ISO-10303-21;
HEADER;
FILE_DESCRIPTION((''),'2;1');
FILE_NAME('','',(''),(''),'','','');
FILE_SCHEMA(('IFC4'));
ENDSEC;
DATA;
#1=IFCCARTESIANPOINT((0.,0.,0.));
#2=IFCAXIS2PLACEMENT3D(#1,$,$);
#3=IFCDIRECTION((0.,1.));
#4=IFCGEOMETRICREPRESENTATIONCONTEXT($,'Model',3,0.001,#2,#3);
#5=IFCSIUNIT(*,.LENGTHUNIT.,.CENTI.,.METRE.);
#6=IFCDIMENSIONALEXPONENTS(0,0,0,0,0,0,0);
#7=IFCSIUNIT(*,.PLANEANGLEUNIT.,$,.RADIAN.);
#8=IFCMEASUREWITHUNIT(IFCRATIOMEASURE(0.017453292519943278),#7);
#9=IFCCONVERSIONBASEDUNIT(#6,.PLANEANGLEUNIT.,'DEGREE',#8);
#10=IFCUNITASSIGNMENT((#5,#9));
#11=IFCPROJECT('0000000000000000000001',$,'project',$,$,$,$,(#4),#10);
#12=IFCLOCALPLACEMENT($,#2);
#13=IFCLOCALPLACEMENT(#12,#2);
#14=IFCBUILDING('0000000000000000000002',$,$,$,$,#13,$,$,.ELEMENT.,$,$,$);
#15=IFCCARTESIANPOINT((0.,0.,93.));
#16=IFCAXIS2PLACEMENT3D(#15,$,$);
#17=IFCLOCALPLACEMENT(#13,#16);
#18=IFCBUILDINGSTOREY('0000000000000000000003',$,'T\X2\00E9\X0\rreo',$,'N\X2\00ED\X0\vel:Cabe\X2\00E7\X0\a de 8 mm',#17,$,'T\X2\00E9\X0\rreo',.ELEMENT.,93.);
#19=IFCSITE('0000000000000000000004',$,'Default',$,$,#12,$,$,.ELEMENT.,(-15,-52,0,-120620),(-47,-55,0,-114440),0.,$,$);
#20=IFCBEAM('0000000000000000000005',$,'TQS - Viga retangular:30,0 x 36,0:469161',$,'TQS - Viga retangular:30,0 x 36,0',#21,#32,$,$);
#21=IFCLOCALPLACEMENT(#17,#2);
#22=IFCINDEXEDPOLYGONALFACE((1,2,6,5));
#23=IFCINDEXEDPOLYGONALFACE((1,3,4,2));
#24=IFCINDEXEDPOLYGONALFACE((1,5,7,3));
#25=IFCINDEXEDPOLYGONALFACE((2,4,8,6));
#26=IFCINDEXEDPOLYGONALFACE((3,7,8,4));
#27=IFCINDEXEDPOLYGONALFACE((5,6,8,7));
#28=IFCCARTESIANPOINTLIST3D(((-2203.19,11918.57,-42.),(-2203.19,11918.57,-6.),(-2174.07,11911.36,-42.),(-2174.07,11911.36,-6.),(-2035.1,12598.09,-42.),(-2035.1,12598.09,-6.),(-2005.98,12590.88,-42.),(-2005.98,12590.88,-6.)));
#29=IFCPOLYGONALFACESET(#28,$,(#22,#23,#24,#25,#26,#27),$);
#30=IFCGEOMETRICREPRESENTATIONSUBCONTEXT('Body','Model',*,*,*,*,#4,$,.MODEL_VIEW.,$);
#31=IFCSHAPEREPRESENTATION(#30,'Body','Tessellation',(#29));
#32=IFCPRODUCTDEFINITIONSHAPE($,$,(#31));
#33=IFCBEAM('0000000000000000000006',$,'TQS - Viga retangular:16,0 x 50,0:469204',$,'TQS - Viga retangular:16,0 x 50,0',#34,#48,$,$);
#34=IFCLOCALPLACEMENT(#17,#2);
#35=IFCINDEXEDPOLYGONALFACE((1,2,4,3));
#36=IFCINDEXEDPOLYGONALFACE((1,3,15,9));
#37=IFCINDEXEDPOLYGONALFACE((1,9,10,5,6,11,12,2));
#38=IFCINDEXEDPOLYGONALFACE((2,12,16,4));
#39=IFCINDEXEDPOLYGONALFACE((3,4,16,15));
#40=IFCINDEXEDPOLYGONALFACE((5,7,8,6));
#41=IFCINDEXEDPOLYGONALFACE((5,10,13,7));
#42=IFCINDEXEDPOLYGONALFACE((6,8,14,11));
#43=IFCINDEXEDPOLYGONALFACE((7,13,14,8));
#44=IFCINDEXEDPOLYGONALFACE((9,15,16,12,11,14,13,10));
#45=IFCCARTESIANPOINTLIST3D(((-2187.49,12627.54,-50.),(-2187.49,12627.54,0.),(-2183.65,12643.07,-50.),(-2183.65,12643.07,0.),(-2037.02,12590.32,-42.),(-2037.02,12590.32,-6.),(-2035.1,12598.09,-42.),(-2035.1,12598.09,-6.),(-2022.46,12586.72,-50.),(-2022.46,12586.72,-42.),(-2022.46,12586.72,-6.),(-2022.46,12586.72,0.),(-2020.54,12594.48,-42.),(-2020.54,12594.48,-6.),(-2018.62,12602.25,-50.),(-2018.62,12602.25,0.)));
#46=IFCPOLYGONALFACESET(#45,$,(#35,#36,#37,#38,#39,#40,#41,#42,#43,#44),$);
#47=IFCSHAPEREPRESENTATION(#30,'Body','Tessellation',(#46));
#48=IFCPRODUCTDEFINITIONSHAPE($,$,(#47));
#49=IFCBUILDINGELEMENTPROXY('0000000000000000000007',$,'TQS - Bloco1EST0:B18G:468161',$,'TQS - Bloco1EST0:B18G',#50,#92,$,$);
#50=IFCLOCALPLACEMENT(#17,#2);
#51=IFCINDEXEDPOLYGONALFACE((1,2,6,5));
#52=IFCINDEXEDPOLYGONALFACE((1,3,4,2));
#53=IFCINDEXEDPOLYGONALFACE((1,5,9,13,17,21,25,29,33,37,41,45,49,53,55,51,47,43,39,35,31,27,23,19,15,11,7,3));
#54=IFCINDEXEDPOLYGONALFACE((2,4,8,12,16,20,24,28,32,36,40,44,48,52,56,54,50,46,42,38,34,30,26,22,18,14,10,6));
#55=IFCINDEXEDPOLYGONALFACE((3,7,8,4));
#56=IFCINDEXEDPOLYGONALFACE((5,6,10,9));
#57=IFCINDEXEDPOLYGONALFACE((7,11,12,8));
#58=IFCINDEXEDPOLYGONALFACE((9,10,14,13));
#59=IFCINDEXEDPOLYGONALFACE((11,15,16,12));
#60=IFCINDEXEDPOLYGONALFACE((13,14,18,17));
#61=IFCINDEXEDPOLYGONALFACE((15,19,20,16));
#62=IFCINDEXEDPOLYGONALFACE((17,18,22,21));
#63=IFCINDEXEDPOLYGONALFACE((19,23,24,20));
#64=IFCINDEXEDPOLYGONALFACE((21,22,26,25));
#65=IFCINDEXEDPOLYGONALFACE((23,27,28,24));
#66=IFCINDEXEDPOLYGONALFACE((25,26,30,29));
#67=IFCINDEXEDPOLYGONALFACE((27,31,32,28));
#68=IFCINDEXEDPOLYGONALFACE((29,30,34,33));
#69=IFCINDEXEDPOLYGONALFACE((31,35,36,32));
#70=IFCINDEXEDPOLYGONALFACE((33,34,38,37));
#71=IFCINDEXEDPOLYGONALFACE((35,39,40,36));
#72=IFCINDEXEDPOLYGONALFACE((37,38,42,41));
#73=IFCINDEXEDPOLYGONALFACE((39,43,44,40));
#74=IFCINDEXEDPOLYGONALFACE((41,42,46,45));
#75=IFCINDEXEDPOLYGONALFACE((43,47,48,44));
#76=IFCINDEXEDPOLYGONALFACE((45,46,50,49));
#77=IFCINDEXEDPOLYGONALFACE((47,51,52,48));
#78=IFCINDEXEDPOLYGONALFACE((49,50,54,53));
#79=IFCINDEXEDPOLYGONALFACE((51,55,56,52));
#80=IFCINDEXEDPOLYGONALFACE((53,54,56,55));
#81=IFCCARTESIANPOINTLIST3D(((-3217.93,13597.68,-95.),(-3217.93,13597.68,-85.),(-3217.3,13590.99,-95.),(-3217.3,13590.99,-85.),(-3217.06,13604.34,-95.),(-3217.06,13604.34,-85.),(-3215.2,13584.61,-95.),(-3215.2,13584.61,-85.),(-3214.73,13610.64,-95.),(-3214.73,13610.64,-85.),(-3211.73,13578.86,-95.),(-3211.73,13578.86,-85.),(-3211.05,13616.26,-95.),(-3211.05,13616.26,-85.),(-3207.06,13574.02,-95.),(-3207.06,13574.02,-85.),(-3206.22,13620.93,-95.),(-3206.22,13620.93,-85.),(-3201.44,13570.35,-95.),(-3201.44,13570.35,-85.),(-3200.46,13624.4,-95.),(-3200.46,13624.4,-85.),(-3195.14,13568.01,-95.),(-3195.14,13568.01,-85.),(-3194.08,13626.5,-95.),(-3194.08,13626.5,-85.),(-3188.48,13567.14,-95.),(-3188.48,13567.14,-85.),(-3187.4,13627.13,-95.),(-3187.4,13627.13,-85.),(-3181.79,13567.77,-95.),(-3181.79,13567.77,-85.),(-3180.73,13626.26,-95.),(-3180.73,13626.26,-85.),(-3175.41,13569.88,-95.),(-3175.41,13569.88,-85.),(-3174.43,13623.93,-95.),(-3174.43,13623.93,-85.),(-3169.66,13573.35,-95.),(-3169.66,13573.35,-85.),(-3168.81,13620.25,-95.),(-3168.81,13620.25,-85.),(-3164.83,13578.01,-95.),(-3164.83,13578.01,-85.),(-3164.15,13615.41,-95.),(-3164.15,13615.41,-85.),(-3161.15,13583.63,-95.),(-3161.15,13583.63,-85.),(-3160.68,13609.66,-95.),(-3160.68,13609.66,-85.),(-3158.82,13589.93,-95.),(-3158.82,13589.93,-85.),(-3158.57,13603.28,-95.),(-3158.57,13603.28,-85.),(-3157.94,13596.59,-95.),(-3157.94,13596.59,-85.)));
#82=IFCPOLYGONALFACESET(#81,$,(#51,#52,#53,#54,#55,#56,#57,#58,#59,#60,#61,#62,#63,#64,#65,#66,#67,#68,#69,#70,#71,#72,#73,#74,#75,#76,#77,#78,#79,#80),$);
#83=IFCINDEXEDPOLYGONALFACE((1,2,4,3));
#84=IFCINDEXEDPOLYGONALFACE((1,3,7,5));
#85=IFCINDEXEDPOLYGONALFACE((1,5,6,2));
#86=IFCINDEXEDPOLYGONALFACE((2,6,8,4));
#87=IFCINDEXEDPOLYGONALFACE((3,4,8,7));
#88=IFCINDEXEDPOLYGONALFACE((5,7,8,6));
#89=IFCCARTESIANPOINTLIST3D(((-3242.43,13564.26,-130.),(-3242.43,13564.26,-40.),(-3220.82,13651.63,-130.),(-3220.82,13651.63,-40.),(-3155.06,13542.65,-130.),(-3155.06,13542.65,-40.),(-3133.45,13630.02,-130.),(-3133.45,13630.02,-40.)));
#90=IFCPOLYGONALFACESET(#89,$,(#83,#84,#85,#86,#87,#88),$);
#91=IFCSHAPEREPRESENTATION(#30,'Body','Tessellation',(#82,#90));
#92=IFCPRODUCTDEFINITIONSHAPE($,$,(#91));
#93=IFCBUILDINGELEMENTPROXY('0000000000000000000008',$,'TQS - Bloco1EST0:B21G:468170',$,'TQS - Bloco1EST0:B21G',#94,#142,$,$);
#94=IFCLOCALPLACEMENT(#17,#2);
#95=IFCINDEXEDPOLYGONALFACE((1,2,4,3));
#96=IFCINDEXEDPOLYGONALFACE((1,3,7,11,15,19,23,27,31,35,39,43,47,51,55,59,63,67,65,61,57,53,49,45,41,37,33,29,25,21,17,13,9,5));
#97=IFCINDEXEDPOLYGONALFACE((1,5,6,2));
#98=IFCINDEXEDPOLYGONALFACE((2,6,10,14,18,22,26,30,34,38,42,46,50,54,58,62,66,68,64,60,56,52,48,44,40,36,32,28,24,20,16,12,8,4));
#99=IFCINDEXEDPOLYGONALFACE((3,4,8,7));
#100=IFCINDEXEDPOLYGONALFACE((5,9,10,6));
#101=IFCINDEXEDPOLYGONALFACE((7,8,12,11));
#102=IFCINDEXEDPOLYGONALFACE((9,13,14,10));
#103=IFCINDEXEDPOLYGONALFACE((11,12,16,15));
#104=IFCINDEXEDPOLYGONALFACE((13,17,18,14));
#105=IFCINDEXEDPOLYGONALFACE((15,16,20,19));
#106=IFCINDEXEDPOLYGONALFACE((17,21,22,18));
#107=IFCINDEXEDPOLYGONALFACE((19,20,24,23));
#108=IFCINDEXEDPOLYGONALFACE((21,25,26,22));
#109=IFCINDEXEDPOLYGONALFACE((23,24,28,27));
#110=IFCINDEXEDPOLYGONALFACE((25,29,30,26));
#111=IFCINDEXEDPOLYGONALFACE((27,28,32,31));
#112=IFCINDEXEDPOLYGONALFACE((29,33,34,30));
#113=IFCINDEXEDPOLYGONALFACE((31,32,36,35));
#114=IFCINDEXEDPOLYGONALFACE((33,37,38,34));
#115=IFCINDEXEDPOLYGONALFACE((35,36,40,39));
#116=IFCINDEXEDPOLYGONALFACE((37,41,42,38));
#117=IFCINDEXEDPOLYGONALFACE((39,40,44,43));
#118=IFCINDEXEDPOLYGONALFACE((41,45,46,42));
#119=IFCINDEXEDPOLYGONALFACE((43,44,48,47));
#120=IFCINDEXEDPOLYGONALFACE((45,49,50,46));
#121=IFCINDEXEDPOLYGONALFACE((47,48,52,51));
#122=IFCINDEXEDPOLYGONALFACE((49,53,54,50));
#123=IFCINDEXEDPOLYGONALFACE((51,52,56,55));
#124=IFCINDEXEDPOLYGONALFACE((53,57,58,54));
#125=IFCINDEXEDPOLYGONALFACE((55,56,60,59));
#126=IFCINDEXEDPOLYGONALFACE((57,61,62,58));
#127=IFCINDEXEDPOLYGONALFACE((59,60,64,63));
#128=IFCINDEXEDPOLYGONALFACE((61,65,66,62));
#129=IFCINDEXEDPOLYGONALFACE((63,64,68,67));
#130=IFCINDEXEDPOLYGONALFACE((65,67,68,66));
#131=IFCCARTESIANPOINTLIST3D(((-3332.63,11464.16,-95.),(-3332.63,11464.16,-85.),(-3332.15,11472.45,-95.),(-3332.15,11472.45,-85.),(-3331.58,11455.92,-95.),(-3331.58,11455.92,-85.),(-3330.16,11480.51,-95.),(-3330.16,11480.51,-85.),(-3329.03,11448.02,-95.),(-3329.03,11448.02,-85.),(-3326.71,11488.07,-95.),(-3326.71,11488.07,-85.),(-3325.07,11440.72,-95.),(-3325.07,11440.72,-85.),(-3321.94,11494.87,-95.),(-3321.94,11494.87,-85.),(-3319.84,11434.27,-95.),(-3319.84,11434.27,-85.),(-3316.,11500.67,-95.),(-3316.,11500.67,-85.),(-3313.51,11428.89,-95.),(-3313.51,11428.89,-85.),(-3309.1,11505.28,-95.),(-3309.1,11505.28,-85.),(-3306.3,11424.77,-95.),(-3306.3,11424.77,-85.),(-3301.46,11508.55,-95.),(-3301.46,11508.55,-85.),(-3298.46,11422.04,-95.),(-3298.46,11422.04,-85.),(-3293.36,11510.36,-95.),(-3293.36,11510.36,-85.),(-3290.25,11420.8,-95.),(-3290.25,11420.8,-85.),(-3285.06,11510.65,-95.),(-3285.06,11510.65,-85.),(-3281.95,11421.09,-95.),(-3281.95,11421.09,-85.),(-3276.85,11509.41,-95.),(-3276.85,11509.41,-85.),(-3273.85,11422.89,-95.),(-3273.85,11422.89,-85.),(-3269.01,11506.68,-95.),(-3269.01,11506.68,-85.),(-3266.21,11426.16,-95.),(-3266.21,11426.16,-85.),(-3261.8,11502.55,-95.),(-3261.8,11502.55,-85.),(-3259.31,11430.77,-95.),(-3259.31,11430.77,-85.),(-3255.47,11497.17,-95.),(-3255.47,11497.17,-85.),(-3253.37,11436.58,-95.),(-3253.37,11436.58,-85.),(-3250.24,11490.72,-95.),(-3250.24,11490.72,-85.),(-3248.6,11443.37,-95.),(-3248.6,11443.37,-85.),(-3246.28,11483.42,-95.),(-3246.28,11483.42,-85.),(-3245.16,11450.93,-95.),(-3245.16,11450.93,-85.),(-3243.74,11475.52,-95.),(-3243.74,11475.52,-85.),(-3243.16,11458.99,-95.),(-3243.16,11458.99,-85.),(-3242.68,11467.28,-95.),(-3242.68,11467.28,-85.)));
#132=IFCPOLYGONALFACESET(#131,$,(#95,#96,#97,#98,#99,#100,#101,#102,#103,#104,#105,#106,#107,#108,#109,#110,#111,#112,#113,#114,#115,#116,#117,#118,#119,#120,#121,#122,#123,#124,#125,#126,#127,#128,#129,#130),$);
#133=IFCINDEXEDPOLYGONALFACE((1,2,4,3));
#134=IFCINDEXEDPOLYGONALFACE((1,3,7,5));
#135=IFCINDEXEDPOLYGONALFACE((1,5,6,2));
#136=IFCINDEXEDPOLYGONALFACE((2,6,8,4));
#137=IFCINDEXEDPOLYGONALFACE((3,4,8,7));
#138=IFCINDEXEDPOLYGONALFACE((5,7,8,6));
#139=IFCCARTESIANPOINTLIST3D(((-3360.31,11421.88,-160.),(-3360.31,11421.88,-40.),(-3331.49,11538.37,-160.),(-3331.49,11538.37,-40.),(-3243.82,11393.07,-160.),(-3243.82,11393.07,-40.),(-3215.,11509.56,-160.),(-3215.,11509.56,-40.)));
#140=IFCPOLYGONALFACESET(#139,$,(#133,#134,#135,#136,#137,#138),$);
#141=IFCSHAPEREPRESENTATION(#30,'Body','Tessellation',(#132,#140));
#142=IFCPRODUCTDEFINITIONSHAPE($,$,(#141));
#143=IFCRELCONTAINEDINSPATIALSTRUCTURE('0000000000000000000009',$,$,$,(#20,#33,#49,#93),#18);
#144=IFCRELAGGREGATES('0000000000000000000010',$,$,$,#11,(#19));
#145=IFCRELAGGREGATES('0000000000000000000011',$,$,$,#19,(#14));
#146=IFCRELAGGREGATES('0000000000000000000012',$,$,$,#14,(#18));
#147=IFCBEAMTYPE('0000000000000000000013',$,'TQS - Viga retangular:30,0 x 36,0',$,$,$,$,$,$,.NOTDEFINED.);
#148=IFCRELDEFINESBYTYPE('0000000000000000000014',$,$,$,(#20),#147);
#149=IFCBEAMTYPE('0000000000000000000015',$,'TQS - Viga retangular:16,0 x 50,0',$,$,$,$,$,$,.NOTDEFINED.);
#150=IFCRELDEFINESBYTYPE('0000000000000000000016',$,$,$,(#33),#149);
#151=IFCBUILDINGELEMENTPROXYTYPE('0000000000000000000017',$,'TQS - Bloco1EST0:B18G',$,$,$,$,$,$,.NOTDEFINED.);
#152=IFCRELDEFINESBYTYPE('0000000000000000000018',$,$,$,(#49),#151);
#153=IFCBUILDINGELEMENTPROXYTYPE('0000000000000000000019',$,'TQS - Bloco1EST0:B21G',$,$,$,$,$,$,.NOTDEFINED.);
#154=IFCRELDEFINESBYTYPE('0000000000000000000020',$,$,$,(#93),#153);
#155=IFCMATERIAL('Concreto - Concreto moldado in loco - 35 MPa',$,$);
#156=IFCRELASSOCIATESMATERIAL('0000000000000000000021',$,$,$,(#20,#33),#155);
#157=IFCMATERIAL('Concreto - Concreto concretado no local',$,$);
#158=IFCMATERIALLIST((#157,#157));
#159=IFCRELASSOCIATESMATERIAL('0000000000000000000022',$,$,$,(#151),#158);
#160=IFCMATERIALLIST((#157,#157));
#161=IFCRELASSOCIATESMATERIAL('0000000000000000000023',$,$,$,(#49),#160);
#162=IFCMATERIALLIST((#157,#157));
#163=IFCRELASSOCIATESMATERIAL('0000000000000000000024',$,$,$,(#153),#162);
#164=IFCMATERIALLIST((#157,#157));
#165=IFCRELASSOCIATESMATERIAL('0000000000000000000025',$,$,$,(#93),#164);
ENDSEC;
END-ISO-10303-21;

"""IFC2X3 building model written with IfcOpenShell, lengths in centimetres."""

from ifc_helpers import new_model, entity, si_unit, converted_unit, direction, frame, frame_2d, origin, origin_2d_with_axis, place, context, subcontext, project, spatial, polyline, rectangle, circle, extrude, boolean, clip, bounded_halfspace, source, transform, mapped, material, material_list, type_object, type_shapes, element, save


model = new_model("IFC2X3")

# Units and contexts
model_context = context("Model", 3, precision=0.001, world=origin(), true_north=direction((0.0, 1.0)))
body_context = subcontext(model_context, "Body", "Model", "MODEL_VIEW")
ifc_project = project(units=[si_unit("LENGTHUNIT", "METRE", prefix="CENTI"), converted_unit("PLANEANGLEUNIT", "DEGREE", entity("IfcRatioMeasure", 0.017453292519943278), si_unit("PLANEANGLEUNIT", "RADIAN"), dimensions=[0, 0, 0, 0, 0, 0, 0])], contexts=[model_context])

# Site, building, storey
site_placement = place(None, origin())
site = spatial("IfcSite", under=ifc_project, at=site_placement, Name="Default", CompositionType="ELEMENT", RefLatitude=(-15, -52, 0, -120620), RefLongitude=(-47, -55, 0, -114440), RefElevation=0.0)
building_placement = place(site_placement, origin())
building = spatial("IfcBuilding", under=site, at=building_placement, CompositionType="ELEMENT")
storey_placement = place(building_placement, frame((0.0, 0.0, 93.0)))
storey = spatial("IfcBuildingStorey", under=building, at=storey_placement, Name="Térreo", ObjectType="Nível:Cabeça de 8 mm", LongName="Térreo", CompositionType="ELEMENT", Elevation=93.0)

# Beams
ifc_material_1 = material(Name="Concreto - Concreto moldado in loco - 35 MPa")
beam_type_1 = type_object("IfcBeamType", Name="TQS - Viga retangular:30,0 x 36,0", PredefinedType="NOTDEFINED")
beam_1_placement = place(storey_placement, frame((-2188.63, 11914.96, -6.0), z_axis=(0.0, 0.0, 1.0), x_axis=(0.240122, 0.970743, 0.0)))
element("IfcBeam", 1, at=beam_1_placement, inside=storey, type_object=beam_type_1, material=ifc_material_1, Name="TQS - Viga retangular:30,0 x 36,0:469161", ObjectType="TQS - Viga retangular:30,0 x 36,0", context=body_context, shape_type="SweptSolid", body=[
    extrude(rectangle(XDim=36.0, YDim=30.0, at=frame_2d((0.0, 0.0), x_axis=(1.0, 0.0))), frame((0.0, 0.0, -18.0), z_axis=(1.0, 0.0, 0.0), x_axis=(0.0, 0.0, -1.0)), (0.0, 0.0, 1.0), 700.0),
])
beam_type_2 = type_object("IfcBeamType", Name="TQS - Viga retangular:16,0 x 50,0", PredefinedType="NOTDEFINED")
beam_2_placement = place(storey_placement, frame((-2020.54, 12594.48, 0.0), z_axis=(0.0, 0.0, 1.0), x_axis=(-0.970743, 0.240122, 0.0)))
element("IfcBeam", 2, at=beam_2_placement, inside=storey, type_object=beam_type_2, material=ifc_material_1, Name="TQS - Viga retangular:16,0 x 50,0:469204", ObjectType="TQS - Viga retangular:16,0 x 50,0", context=body_context, shape_type="SweptSolid", body=[
    boolean("DIFFERENCE", clip(extrude(rectangle(XDim=50.0, YDim=16.0, at=frame_2d((0.0, 0.0), x_axis=(1.0, 0.0))), frame((0.0, 0.0, -25.0), z_axis=(1.0, 0.0, 0.0), x_axis=(0.0, 0.0, -1.0)), (0.0, 0.0, 1.0), 170.0), bounded_halfspace(frame((15.0, 0.0, -42.0), z_axis=(-1.0, 0.0, 0.0), x_axis=(0.0, 1.0, 0.0)), False, frame((0.0, 0.0, -25.0), z_axis=(1.0, 0.0, 0.0), x_axis=(0.0, 0.0, -1.0)), polyline([(17.0, 0.0), (-19.0, 0.0), (-19.0, 8.0), (-9.0, 8.0), (17.0, 8.0), (17.0, 0.0)]))), extrude(rectangle(XDim=36.0, YDim=8.0, at=frame_2d((0.0, 0.0), x_axis=(0.0, 1.0))), frame((0.0, 4.0, -24.0), z_axis=(-1.0, 0.0, 0.0), x_axis=(0.0, -1.0, 0.0)), (0.0, 0.0, -1.0), 15.0)),
])

# Building element proxies
ifc_material_2 = material(Name="Concreto - Concreto concretado no local")
ifc_material_list_1 = material_list([ifc_material_2, ifc_material_2])
ifc_material_list_2 = material_list([ifc_material_2, ifc_material_2])
building_element_proxy_type_1 = type_object("IfcBuildingElementProxyType", Name="TQS - Bloco1EST0:B18G", PredefinedType="NOTDEFINED", material=ifc_material_list_2)
shared_shape_1 = source(origin(), body_context, "Body", "SweptSolid", [
    extrude(circle(Radius=30.0, at=frame_2d((0.0, 0.0), x_axis=(1.0, 0.0))), frame((0.0, 0.0, -55.0)), (0.0, 0.0, 1.0), 10.0),
    extrude(rectangle(XDim=90.0, YDim=90.0, at=origin_2d_with_axis()), frame((0.0, 0.0, -90.0), z_axis=(0.0, 0.0, 1.0), x_axis=(-1.0, 0.0, 0.0)), (0.0, 0.0, 1.0), 90.0),
])
type_shapes(building_element_proxy_type_1, [shared_shape_1])
proxy_1_placement = place(storey_placement, frame((-3187.94, 13597.14, -40.0), z_axis=(0.0, 0.0, 1.0), x_axis=(0.240122, 0.970743, 0.0)))
element("IfcBuildingElementProxy", 3, at=proxy_1_placement, inside=storey, type_object=building_element_proxy_type_1, material=ifc_material_list_1, Name="TQS - Bloco1EST0:B18G:468161", ObjectType="TQS - Bloco1EST0:B18G", context=body_context, shape_type="MappedRepresentation", body=[
    mapped(shared_shape_1, transform((0.0, 0.0, 0.0), scale=1.0)),
])
ifc_material_list_3 = material_list([ifc_material_2, ifc_material_2])
ifc_material_list_4 = material_list([ifc_material_2, ifc_material_2])
building_element_proxy_type_2 = type_object("IfcBuildingElementProxyType", Name="TQS - Bloco1EST0:B21G", PredefinedType="NOTDEFINED", material=ifc_material_list_4)
shared_shape_2 = source(origin(), body_context, "Body", "SweptSolid", [
    extrude(circle(Radius=45.0, at=frame_2d((0.0, 0.0), x_axis=(1.0, 0.0))), frame((0.0, 0.0, -55.0)), (0.0, 0.0, 1.0), 10.0),
    extrude(rectangle(XDim=120.0, YDim=120.0, at=origin_2d_with_axis()), frame((0.0, 0.0, -120.0), z_axis=(0.0, 0.0, 1.0), x_axis=(-1.0, 0.0, 0.0)), (0.0, 0.0, 1.0), 120.0),
])
type_shapes(building_element_proxy_type_2, [shared_shape_2])
proxy_2_placement = place(storey_placement, frame((-3287.66, 11465.72, -40.0), z_axis=(0.0, 0.0, 1.0), x_axis=(0.240122, 0.970743, 0.0)))
element("IfcBuildingElementProxy", 4, at=proxy_2_placement, inside=storey, type_object=building_element_proxy_type_2, material=ifc_material_list_3, Name="TQS - Bloco1EST0:B21G:468170", ObjectType="TQS - Bloco1EST0:B21G", context=body_context, shape_type="MappedRepresentation", body=[
    mapped(shared_shape_2, transform((0.0, 0.0, 0.0), scale=1.0)),
])

save(model, "model.ifc")
